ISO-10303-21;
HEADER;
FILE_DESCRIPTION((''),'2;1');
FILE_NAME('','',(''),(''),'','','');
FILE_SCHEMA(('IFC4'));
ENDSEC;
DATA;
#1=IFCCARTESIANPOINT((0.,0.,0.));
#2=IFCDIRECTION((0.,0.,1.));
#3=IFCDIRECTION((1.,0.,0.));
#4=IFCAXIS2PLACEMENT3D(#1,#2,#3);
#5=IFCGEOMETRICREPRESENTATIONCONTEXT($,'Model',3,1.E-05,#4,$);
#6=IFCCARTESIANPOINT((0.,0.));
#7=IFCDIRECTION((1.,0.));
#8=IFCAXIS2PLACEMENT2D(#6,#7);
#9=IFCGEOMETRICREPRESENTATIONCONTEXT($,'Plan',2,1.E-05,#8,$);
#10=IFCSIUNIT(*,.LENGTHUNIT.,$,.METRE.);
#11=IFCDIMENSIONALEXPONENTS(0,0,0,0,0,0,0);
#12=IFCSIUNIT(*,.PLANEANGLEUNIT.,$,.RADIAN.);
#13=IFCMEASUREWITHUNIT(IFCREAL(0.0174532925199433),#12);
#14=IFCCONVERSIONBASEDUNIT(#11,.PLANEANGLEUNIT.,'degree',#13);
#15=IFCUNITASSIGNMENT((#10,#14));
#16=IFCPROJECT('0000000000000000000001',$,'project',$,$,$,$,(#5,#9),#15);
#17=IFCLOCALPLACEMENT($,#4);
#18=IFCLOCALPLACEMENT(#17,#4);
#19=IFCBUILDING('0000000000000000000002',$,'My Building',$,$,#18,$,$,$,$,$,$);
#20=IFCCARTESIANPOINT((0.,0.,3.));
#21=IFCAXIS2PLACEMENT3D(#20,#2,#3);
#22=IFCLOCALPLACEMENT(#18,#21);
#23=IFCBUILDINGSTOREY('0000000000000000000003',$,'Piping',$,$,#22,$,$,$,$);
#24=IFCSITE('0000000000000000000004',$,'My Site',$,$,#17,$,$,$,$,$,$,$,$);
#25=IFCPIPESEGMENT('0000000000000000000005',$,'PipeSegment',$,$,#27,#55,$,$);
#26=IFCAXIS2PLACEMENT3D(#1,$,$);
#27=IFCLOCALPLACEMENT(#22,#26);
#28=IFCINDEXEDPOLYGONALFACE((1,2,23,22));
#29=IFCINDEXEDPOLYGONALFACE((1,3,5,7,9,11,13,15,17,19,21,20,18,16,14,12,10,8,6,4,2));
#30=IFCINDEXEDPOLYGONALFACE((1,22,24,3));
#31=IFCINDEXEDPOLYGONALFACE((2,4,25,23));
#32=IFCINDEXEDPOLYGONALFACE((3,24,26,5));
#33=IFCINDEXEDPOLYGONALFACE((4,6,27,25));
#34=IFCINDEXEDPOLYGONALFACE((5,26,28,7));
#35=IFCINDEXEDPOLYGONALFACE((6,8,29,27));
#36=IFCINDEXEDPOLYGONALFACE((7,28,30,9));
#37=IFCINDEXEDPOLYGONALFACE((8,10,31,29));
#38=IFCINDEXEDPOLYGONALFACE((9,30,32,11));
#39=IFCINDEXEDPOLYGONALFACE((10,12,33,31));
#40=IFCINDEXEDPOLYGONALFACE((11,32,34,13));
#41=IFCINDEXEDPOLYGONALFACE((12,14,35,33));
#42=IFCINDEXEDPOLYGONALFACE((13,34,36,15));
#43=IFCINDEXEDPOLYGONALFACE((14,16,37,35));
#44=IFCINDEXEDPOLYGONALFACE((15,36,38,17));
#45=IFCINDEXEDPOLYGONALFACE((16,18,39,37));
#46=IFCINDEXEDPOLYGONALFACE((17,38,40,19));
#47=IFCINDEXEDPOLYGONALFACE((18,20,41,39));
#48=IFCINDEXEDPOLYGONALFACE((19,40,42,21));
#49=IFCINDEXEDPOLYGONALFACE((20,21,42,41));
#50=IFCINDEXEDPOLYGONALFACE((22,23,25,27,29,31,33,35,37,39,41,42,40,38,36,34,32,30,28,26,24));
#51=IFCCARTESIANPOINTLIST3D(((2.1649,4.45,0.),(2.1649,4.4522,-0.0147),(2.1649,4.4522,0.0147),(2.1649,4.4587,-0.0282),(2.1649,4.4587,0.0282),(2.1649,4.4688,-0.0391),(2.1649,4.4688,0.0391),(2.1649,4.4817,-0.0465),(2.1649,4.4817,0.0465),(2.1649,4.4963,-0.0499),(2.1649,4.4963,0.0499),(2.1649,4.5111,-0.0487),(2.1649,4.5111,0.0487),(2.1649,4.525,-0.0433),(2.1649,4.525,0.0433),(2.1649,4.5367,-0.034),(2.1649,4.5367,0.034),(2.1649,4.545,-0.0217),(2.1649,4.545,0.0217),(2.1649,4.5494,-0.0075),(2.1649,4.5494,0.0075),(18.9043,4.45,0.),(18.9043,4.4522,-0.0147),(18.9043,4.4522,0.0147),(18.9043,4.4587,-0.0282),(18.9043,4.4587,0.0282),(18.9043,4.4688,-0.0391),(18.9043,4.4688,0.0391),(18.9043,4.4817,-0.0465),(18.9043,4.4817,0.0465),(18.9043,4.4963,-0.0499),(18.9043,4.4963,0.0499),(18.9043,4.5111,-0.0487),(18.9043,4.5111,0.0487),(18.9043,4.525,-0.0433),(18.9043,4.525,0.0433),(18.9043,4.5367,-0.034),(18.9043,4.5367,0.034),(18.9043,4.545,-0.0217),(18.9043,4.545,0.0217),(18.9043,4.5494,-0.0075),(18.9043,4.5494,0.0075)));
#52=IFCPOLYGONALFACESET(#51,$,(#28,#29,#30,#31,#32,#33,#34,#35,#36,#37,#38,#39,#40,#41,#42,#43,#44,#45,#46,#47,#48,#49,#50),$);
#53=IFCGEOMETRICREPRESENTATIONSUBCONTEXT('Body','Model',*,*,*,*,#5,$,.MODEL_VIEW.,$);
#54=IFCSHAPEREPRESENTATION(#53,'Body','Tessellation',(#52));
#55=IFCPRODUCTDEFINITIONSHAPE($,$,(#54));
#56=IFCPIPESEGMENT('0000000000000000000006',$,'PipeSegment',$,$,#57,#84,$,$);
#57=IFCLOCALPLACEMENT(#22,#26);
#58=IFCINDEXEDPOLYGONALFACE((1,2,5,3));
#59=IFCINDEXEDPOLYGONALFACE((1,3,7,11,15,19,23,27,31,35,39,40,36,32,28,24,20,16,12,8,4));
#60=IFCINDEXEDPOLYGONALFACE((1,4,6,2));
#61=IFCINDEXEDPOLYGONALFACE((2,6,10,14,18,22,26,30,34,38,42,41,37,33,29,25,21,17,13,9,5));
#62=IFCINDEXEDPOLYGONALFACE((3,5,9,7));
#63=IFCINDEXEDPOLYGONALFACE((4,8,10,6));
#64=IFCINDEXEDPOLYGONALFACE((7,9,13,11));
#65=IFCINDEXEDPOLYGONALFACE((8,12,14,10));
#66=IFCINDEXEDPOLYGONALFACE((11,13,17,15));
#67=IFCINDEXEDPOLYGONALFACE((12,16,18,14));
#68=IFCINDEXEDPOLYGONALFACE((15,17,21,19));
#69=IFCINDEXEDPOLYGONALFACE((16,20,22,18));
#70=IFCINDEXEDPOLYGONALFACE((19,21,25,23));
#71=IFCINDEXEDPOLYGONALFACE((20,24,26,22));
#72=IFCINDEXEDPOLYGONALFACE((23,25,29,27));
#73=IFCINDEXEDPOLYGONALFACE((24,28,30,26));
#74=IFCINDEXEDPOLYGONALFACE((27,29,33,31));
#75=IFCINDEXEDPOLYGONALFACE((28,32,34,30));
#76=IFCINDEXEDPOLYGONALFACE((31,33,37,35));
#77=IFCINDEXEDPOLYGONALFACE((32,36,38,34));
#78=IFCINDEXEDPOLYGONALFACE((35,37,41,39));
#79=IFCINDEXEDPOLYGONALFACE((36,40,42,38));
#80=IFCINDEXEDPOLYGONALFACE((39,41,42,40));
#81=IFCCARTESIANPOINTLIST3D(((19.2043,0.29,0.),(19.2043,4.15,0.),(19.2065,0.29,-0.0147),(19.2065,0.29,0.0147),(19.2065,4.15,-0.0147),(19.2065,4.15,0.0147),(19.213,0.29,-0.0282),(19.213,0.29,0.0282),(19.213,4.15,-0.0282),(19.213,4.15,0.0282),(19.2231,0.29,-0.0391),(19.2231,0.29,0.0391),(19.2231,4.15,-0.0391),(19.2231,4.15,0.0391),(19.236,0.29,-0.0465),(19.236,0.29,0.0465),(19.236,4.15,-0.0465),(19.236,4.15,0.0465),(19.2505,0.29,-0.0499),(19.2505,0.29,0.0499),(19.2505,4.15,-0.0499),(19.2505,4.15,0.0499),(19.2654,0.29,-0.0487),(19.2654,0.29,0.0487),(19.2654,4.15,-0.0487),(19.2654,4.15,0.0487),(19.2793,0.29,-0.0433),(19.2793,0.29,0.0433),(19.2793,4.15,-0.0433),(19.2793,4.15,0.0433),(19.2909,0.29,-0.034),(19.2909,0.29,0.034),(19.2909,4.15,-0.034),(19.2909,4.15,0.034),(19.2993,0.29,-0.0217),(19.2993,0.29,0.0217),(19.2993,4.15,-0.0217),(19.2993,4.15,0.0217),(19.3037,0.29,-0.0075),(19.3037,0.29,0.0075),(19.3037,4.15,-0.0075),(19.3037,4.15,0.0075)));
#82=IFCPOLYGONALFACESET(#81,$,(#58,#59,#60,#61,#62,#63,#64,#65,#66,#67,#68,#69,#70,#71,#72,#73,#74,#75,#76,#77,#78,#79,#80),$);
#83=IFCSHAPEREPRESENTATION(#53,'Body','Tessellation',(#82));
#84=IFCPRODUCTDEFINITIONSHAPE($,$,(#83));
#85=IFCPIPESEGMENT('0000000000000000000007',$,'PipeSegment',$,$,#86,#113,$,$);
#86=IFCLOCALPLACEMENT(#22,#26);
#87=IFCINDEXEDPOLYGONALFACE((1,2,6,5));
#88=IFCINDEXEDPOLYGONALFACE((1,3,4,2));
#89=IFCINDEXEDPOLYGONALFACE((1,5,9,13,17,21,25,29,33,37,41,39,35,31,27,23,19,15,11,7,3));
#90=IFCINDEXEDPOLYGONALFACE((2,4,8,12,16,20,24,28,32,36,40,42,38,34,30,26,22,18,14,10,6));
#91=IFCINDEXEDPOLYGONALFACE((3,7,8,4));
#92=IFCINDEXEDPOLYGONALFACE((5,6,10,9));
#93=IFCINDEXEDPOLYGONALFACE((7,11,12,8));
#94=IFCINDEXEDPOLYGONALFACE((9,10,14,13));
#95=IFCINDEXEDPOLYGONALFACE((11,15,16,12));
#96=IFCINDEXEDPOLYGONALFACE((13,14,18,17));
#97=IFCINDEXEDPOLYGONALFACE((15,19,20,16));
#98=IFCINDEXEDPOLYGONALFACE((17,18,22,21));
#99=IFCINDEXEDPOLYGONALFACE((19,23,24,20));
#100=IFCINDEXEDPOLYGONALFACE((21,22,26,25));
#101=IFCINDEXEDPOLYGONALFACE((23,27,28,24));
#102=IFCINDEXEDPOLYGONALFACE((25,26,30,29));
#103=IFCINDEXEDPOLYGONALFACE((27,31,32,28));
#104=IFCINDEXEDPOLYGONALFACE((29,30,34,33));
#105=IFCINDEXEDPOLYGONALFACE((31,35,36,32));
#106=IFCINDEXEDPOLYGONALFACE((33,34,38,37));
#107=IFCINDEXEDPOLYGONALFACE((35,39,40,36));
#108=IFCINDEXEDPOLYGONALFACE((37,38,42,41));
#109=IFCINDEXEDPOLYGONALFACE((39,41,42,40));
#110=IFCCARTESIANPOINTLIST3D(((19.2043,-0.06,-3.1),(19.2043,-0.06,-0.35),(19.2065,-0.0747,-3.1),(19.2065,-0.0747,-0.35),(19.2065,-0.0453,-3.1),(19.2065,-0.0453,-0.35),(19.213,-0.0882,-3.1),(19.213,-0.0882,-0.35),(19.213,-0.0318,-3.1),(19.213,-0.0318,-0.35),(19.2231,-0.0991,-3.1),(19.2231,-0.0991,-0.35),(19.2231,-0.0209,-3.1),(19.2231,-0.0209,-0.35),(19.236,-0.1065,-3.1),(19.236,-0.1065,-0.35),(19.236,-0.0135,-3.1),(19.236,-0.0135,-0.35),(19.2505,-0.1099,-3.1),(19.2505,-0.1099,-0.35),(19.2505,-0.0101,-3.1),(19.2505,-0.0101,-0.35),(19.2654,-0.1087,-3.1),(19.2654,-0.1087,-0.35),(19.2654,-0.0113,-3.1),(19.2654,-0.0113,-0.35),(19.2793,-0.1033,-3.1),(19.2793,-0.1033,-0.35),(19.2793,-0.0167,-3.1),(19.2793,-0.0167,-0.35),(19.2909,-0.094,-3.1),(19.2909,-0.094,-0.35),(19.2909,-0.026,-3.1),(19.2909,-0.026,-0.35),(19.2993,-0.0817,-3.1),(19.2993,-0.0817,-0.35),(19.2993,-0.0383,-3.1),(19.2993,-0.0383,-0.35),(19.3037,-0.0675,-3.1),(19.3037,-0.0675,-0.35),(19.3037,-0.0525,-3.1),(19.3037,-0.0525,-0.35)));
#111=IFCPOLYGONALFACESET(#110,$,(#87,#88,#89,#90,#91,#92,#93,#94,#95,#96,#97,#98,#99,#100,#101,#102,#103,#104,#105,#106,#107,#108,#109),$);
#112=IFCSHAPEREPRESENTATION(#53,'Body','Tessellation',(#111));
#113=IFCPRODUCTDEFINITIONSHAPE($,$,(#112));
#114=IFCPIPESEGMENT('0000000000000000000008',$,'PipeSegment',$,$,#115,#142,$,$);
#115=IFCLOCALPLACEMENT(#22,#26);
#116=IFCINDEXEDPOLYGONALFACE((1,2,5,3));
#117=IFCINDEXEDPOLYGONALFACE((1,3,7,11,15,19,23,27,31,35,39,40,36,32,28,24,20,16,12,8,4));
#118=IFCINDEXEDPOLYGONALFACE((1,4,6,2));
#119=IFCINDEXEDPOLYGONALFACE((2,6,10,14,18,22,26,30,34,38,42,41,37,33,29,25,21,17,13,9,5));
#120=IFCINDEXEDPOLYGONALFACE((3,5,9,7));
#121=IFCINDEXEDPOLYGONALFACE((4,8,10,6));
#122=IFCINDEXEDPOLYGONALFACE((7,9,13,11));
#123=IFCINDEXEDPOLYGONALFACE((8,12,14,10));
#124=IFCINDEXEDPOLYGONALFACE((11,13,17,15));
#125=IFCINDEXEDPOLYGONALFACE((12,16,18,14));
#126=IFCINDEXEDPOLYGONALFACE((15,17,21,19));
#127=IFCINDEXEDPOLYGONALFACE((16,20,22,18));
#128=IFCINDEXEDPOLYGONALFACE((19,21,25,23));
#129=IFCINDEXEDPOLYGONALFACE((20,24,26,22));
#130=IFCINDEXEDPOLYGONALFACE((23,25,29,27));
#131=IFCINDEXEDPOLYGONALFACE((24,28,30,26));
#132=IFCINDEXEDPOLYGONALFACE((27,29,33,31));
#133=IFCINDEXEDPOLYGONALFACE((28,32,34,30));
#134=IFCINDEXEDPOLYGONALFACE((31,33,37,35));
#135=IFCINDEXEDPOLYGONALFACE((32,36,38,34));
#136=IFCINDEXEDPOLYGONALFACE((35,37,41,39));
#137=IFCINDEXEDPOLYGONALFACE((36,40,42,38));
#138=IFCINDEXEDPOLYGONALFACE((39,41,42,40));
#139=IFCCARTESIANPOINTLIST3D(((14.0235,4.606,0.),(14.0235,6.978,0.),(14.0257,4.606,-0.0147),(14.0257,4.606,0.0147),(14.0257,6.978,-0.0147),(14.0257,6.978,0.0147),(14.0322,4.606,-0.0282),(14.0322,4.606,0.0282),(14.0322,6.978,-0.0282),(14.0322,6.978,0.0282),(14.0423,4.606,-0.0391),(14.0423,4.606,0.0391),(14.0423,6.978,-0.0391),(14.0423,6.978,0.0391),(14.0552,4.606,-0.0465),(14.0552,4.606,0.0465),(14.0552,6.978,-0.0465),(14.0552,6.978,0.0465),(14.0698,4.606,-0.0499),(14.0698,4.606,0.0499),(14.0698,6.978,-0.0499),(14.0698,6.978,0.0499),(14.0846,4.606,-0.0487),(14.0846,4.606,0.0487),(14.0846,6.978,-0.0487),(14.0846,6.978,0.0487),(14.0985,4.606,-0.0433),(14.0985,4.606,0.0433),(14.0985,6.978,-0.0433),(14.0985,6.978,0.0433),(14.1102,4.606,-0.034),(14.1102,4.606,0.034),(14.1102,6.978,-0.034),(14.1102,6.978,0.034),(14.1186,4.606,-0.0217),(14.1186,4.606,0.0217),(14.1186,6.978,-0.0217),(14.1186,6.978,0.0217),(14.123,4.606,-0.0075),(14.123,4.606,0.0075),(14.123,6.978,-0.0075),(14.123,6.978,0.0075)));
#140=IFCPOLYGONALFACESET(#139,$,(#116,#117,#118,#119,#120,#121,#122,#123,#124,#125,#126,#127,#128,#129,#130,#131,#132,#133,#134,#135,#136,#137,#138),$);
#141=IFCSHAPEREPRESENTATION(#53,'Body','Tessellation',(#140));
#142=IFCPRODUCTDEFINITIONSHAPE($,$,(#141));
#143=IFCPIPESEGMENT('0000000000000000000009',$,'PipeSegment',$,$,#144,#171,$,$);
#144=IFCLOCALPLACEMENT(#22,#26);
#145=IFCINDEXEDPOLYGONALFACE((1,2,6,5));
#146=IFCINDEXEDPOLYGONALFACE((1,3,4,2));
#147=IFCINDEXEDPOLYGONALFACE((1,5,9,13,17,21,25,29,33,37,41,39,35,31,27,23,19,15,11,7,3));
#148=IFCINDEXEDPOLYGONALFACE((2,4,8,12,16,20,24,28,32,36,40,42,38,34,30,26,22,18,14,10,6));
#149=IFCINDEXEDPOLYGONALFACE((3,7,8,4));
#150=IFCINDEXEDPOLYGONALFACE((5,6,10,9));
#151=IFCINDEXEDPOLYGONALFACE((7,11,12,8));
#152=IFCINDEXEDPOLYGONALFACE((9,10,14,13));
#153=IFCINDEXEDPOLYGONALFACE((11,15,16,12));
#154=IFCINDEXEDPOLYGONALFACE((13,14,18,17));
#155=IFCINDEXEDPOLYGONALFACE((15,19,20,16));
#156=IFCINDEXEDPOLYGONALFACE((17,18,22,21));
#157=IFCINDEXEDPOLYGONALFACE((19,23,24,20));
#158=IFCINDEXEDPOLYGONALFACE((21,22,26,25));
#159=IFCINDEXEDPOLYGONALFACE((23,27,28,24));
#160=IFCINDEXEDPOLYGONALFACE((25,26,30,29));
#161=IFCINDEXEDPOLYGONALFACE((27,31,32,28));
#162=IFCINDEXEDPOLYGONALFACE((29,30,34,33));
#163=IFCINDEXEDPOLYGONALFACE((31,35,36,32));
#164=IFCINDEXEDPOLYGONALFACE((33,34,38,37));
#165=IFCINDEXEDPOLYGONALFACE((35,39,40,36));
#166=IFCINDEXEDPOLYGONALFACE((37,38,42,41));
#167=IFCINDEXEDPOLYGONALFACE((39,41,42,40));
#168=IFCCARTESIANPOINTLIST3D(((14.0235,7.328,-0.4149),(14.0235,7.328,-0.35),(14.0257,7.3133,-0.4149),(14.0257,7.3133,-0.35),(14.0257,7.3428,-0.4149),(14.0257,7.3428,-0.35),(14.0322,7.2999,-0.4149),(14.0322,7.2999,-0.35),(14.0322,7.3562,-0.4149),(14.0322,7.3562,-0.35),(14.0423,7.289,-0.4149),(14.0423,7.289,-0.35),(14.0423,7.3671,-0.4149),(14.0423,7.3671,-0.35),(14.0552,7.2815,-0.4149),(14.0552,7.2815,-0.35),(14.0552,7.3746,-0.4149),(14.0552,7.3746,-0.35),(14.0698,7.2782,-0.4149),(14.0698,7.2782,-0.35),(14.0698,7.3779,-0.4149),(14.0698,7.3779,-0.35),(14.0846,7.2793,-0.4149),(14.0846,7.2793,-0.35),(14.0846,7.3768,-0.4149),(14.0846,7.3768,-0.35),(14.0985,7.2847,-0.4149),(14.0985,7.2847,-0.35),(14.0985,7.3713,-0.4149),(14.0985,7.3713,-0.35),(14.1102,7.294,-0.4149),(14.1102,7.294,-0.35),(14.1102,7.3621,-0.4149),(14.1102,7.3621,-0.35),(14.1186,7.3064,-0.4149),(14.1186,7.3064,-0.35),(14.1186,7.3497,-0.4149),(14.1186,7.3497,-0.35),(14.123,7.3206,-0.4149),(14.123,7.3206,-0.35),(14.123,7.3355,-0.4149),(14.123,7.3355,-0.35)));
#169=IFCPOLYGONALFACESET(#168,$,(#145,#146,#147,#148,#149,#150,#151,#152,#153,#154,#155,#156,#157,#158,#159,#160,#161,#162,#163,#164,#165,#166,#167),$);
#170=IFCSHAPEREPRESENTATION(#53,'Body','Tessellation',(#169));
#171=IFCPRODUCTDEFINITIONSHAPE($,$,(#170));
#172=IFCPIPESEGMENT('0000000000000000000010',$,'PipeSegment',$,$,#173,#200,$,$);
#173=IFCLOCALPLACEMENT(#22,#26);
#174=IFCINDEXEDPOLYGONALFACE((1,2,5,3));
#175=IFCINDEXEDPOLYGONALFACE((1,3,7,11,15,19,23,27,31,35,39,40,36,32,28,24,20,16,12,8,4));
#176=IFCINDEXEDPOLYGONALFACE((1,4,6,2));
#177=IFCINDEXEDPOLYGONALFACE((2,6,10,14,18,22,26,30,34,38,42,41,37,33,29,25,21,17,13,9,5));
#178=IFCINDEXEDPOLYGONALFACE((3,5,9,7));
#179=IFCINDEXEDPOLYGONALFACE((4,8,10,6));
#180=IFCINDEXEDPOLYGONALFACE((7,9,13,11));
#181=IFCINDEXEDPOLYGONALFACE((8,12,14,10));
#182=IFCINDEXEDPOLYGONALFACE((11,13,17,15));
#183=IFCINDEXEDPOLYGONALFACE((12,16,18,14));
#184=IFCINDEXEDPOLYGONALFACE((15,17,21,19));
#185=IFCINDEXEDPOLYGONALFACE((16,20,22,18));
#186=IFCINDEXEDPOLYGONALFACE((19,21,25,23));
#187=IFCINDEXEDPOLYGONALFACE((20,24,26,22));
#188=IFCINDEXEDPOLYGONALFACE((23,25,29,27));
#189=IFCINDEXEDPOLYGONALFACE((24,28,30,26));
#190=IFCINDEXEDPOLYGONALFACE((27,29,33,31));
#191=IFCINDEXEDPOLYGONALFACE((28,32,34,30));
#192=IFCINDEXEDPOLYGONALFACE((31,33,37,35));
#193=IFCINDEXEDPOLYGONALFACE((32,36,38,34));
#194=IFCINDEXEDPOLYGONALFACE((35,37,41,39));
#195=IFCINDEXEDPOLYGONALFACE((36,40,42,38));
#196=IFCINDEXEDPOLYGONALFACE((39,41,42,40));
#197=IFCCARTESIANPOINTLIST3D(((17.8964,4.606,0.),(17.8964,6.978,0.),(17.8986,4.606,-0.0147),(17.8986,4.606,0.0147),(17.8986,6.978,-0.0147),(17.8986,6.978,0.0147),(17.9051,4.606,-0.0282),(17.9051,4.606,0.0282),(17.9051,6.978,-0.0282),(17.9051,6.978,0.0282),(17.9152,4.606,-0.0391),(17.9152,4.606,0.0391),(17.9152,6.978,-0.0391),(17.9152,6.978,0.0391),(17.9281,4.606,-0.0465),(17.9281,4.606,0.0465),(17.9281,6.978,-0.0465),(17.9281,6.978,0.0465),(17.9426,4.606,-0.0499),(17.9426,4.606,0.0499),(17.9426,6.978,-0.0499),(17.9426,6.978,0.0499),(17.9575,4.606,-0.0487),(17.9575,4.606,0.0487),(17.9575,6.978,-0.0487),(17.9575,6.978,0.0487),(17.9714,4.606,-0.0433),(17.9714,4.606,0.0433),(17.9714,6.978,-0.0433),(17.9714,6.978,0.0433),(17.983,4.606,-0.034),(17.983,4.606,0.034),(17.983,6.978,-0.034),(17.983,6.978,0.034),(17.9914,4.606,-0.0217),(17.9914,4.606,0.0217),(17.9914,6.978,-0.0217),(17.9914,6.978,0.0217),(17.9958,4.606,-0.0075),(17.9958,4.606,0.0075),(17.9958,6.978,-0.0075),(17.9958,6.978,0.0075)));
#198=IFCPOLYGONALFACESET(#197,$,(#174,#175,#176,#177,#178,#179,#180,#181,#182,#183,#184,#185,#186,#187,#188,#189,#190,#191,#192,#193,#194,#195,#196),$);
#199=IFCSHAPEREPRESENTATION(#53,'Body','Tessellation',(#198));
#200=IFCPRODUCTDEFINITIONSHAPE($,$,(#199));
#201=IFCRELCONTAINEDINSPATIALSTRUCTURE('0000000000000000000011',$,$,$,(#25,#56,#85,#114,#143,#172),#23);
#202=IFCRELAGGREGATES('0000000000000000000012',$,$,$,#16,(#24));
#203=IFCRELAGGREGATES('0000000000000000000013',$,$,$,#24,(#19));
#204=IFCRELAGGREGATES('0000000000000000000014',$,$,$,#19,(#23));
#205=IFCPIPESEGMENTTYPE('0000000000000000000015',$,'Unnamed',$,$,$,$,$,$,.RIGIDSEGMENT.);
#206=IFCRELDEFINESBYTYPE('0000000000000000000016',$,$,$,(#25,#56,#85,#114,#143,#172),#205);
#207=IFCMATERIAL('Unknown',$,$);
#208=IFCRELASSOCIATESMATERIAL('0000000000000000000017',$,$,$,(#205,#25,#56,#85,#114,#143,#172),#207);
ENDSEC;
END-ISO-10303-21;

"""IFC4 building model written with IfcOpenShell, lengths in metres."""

from ifc_helpers import new_model, entity, si_unit, converted_unit, frame, origin_with_axes, origin_2d_with_axis, place, context, subcontext, project, spatial, circle, extrude, material, material_profile, profile_set, profile_usage, type_object, element, save


model = new_model("IFC4")

# Units and contexts
model_context = context("Model", 3, precision=1e-05, world=origin_with_axes())
plan_context = context("Plan", 2, precision=1e-05, world=origin_2d_with_axis())
body_context = subcontext(model_context, "Body", "Model", "MODEL_VIEW")
ifc_project = project(units=[si_unit("LENGTHUNIT", "METRE"), converted_unit("PLANEANGLEUNIT", "degree", entity("IfcReal", 0.0174532925199433), si_unit("PLANEANGLEUNIT", "RADIAN"), dimensions=[0, 0, 0, 0, 0, 0, 0])], contexts=[model_context, plan_context])

# Site, building, storey
site_placement = place(None, origin_with_axes())
site = spatial("IfcSite", under=ifc_project, at=site_placement, Name="My Site")
building_placement = place(site_placement, origin_with_axes())
building = spatial("IfcBuilding", under=site, at=building_placement, Name="My Building")
storey_placement = place(building_placement, frame((0.0, 0.0, 3.0), z_axis=(0.0, 0.0, 1.0), x_axis=(1.0, 0.0, 0.0)))
storey = spatial("IfcBuildingStorey", under=building, at=storey_placement, Name="Piping")

# Pipe segments
ifc_material = material(Name="Unknown")
ifc_material_profile_1 = material_profile(ifc_material, circle(Radius=0.05))
ifc_profile_set_1 = profile_set([ifc_material_profile_1])
ifc_profile_usage_1 = profile_usage(ifc_profile_set_1, cardinal=5)
pipe_segment_type = type_object("IfcPipeSegmentType", Name="Unnamed", PredefinedType="RIGIDSEGMENT", material=ifc_profile_set_1)
pipe_segment_1_placement = place(storey_placement, frame((18.9043, 4.5, 0.0), z_axis=(-1.0, 0.0, 0.0), x_axis=(0.0, -1.0, 0.0)))
element("IfcPipeSegment", 1, at=pipe_segment_1_placement, inside=storey, type_object=pipe_segment_type, material=ifc_profile_usage_1, Name="PipeSegment", context=body_context, shape_type="SweptSolid", body=[
    extrude(circle(Radius=0.05), origin_with_axes(), (0.0, 0.0, 1.0), 16.7394),
])
ifc_profile_usage_2 = profile_usage(ifc_profile_set_1, cardinal=5)
pipe_segment_2_placement = place(storey_placement, frame((19.2543, 0.29, 0.0), z_axis=(0.0, 1.0, 0.0), x_axis=(-1.0, 0.0, 0.0)))
element("IfcPipeSegment", 2, at=pipe_segment_2_placement, inside=storey, type_object=pipe_segment_type, material=ifc_profile_usage_2, Name="PipeSegment", context=body_context, shape_type="SweptSolid", body=[
    extrude(circle(Radius=0.05), origin_with_axes(), (0.0, 0.0, 1.0), 3.86),
])
ifc_profile_usage_3 = profile_usage(ifc_profile_set_1, cardinal=5)
pipe_segment_3_placement = place(storey_placement, frame((19.2543, -0.06, -0.35), z_axis=(0.0, 0.0, -1.0), x_axis=(-1.0, 0.0, 0.0)))
element("IfcPipeSegment", 3, at=pipe_segment_3_placement, inside=storey, type_object=pipe_segment_type, material=ifc_profile_usage_3, Name="PipeSegment", context=body_context, shape_type="SweptSolid", body=[
    extrude(circle(Radius=0.05), origin_with_axes(), (0.0, 0.0, 1.0), 2.75),
])
ifc_profile_usage_4 = profile_usage(ifc_profile_set_1, cardinal=5)
pipe_segment_4_placement = place(storey_placement, frame((14.0735, 4.606, 0.0), z_axis=(0.0, 1.0, 0.0), x_axis=(-1.0, 0.0, 0.0)))
element("IfcPipeSegment", 4, at=pipe_segment_4_placement, inside=storey, type_object=pipe_segment_type, material=ifc_profile_usage_4, Name="PipeSegment", context=body_context, shape_type="SweptSolid", body=[
    extrude(circle(Radius=0.05), origin_with_axes(), (0.0, 0.0, 1.0), 2.372),
])
ifc_profile_usage_5 = profile_usage(ifc_profile_set_1, cardinal=5)
pipe_segment_5_placement = place(storey_placement, frame((14.0735, 7.328, -0.35), z_axis=(0.0, 0.0, -1.0), x_axis=(-1.0, 0.0, 0.0)))
element("IfcPipeSegment", 5, at=pipe_segment_5_placement, inside=storey, type_object=pipe_segment_type, material=ifc_profile_usage_5, Name="PipeSegment", context=body_context, shape_type="SweptSolid", body=[
    extrude(circle(Radius=0.05), origin_with_axes(), (0.0, 0.0, 1.0), 0.0649),
])
ifc_profile_usage_6 = profile_usage(ifc_profile_set_1, cardinal=5)
pipe_segment_6_placement = place(storey_placement, frame((17.9464, 4.606, 0.0), z_axis=(0.0, 1.0, 0.0), x_axis=(-1.0, 0.0, 0.0)))
element("IfcPipeSegment", 6, at=pipe_segment_6_placement, inside=storey, type_object=pipe_segment_type, material=ifc_profile_usage_6, Name="PipeSegment", context=body_context, shape_type="SweptSolid", body=[
    extrude(circle(Radius=0.05), origin_with_axes(), (0.0, 0.0, 1.0), 2.372),
])

save(model, "model.ifc")
